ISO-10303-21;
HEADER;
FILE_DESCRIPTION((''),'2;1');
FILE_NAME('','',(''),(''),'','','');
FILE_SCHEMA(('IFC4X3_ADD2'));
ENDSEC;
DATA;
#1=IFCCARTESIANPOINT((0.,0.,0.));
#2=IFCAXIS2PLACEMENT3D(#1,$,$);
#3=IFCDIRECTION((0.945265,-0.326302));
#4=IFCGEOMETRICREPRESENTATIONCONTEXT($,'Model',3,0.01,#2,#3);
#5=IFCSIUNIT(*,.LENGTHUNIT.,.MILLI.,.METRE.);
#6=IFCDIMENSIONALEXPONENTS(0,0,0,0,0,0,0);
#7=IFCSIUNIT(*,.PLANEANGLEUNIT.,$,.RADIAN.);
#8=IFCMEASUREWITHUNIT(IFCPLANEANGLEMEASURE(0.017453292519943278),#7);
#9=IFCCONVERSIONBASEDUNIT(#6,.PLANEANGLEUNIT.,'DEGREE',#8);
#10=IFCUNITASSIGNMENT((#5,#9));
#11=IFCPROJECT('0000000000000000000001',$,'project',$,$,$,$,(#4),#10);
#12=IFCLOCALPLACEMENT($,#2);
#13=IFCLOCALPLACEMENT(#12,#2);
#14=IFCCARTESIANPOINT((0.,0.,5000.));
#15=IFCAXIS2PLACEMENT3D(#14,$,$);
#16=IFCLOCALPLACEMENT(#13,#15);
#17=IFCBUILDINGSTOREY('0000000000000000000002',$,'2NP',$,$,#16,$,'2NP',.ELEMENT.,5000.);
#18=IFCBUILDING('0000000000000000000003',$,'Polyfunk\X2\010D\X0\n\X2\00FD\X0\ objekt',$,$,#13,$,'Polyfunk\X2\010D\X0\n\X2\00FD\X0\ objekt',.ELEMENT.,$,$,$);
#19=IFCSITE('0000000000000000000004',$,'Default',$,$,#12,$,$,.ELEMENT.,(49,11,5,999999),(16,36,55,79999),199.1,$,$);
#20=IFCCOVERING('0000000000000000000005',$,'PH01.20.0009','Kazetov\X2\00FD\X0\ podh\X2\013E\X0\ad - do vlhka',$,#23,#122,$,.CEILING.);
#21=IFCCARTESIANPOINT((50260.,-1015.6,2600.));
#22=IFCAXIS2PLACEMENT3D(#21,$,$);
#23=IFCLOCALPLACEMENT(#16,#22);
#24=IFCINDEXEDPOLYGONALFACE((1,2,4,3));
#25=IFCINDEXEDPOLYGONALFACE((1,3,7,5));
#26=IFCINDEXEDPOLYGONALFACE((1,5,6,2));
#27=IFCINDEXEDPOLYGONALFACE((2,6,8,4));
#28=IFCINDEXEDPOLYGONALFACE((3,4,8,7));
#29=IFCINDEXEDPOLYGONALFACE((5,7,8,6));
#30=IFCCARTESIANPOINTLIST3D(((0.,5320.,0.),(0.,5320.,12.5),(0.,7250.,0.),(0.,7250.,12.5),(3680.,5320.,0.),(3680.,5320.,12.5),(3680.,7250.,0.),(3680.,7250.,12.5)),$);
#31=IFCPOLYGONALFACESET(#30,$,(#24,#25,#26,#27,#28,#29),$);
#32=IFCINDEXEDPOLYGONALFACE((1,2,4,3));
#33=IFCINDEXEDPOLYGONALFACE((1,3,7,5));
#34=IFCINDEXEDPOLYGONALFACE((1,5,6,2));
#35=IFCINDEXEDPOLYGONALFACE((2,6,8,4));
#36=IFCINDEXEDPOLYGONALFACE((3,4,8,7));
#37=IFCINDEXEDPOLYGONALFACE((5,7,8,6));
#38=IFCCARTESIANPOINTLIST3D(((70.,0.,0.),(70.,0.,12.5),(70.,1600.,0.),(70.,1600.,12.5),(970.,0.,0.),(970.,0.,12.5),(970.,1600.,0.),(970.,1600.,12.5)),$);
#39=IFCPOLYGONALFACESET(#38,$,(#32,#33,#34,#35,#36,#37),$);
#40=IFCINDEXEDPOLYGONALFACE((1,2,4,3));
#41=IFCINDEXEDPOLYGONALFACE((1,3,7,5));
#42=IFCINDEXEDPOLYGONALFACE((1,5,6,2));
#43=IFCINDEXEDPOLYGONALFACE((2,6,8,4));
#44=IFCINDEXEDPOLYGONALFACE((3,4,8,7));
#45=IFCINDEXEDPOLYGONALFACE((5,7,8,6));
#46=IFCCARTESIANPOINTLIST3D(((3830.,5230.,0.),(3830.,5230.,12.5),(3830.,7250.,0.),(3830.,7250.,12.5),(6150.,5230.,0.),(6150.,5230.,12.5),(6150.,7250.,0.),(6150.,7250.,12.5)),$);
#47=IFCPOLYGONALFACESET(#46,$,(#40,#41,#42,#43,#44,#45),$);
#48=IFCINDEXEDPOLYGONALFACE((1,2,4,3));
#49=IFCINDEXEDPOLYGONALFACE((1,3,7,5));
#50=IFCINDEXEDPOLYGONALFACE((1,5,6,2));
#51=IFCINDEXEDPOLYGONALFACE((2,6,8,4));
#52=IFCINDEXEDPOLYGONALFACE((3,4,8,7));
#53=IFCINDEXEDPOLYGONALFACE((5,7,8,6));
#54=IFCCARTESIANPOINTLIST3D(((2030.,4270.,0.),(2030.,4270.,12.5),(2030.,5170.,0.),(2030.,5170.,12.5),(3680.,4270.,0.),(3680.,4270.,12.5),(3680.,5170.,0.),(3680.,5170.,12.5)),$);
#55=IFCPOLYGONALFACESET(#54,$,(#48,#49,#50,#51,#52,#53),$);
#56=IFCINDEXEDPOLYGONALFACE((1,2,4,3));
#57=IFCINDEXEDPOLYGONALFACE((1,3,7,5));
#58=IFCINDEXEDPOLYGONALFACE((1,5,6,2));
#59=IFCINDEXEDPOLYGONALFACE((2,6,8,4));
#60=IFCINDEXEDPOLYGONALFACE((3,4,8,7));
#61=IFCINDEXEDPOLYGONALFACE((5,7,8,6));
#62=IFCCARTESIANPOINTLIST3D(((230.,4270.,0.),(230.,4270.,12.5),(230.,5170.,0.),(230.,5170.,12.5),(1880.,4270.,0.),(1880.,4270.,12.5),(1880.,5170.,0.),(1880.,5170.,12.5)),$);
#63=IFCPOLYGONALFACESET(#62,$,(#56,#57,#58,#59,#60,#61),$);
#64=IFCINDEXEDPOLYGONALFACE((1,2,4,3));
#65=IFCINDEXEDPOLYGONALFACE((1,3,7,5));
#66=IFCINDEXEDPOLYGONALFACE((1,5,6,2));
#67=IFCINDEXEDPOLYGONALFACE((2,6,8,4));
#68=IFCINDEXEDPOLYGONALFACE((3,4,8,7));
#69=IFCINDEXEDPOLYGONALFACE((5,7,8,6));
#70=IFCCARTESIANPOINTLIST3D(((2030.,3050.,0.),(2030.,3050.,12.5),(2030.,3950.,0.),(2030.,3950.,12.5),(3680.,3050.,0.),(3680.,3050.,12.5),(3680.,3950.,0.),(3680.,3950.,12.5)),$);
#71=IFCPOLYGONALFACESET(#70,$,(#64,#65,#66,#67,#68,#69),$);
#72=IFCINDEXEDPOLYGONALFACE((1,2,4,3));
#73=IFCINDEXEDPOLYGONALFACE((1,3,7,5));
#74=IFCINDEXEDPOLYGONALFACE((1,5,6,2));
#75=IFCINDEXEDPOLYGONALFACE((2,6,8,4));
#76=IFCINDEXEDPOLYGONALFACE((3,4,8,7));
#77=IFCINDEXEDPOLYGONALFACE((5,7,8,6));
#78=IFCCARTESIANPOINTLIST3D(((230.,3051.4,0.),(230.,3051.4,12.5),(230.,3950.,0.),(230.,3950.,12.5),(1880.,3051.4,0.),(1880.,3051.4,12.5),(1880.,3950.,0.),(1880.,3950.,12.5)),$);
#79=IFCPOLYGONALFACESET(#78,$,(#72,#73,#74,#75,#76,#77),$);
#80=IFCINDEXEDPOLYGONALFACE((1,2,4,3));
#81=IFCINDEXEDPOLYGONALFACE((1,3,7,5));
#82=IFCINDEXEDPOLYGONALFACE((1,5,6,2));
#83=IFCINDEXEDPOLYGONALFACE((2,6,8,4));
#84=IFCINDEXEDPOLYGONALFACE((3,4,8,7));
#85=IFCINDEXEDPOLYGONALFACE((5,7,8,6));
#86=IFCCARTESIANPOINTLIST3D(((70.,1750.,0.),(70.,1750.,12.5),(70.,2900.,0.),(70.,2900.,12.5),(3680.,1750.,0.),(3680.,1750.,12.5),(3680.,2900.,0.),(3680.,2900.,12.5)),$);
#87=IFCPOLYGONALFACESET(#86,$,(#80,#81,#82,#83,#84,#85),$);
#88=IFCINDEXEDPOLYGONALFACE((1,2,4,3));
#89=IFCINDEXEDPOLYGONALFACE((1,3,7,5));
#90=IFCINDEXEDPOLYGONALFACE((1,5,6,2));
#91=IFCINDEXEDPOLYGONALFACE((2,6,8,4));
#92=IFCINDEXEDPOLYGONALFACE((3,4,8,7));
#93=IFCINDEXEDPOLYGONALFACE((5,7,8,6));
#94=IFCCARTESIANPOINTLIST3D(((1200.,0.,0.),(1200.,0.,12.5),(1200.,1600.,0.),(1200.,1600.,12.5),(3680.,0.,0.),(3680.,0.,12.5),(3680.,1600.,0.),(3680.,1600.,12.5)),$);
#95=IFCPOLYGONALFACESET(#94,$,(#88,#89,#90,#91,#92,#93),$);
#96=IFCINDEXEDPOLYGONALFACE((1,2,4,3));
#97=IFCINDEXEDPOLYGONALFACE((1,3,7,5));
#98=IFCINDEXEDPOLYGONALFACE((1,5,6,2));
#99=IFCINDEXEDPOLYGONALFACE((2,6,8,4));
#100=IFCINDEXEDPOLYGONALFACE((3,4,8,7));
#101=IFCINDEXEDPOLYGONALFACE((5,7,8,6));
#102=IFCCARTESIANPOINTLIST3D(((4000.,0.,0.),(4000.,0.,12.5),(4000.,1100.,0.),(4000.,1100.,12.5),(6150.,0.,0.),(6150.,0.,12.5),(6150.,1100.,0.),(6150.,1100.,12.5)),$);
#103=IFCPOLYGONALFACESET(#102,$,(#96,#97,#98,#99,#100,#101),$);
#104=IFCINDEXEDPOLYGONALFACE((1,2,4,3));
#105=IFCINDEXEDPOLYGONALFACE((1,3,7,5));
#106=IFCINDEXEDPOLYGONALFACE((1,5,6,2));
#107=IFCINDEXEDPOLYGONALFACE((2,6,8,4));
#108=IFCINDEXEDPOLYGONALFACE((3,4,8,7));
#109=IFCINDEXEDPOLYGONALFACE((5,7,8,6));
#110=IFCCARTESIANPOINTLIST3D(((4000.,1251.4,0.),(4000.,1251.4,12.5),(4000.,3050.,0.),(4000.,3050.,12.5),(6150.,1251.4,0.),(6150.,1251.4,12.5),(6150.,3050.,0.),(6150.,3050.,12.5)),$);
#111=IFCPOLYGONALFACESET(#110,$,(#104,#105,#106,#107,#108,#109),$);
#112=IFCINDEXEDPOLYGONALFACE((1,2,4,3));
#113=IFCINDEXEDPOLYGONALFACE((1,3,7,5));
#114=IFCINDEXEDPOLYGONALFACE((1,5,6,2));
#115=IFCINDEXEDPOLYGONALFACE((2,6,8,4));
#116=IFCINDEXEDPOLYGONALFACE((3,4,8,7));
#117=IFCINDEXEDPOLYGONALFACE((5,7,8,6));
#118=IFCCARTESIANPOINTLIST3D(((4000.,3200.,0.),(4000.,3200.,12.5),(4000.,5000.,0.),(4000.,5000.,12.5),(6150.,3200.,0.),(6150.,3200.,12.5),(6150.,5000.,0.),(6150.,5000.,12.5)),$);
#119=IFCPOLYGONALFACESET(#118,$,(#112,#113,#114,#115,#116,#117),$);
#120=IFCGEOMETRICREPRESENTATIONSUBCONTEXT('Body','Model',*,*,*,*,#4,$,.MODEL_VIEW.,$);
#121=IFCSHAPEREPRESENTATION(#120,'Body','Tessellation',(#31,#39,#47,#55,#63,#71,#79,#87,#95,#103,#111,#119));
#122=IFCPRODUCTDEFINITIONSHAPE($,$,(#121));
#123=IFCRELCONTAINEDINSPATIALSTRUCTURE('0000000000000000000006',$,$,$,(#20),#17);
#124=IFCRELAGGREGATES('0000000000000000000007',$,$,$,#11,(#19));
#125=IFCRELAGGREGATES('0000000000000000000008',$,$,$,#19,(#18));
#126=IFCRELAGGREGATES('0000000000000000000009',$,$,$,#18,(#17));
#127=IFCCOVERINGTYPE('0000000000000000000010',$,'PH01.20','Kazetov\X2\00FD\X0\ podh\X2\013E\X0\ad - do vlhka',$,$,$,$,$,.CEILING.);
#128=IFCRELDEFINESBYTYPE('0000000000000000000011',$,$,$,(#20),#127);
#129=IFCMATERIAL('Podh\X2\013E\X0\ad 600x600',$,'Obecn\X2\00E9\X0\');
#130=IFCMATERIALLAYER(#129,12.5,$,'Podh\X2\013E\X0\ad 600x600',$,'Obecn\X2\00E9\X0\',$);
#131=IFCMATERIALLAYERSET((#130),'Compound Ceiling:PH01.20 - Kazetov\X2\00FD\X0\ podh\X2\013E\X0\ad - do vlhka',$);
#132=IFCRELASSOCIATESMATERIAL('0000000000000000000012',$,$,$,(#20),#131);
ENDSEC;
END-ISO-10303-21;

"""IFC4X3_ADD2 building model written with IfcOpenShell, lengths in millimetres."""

from ifc_helpers import new_model, entity, si_unit, converted_unit, direction, frame, frame_2d, origin, origin_2d_with_axis, place, context, subcontext, project, spatial, rectangle, extrude, material, layer, layer_set, layer_usage, type_object, element, save


model = new_model("IFC4X3_ADD2")

# Units and contexts
model_context = context("Model", 3, precision=0.01, world=origin(), true_north=direction((0.945265, -0.326302)))
body_context = subcontext(model_context, "Body", "Model", "MODEL_VIEW")
ifc_project = project(units=[si_unit("LENGTHUNIT", "METRE", prefix="MILLI"), converted_unit("PLANEANGLEUNIT", "DEGREE", entity("IfcPlaneAngleMeasure", 0.017453292519943278), si_unit("PLANEANGLEUNIT", "RADIAN"), dimensions=[0, 0, 0, 0, 0, 0, 0])], contexts=[model_context])

# Site, building, storey
site_placement = place(None, origin())
site = spatial("IfcSite", under=ifc_project, at=site_placement, Name="Default", CompositionType="ELEMENT", RefLatitude=(49, 11, 5, 999999), RefLongitude=(16, 36, 55, 79999), RefElevation=199.1)
building_placement = place(site_placement, origin())
building = spatial("IfcBuilding", under=site, at=building_placement, Name="Polyfunkčný objekt", LongName="Polyfunkčný objekt", CompositionType="ELEMENT")
storey_placement = place(building_placement, frame((0.0, 0.0, 5000.0)))
storey = spatial("IfcBuildingStorey", under=building, at=storey_placement, Name="2NP", LongName="2NP", CompositionType="ELEMENT", Elevation=5000.0)

# Covering
ifc_material_1 = material(Name="Podhľad 600x600", Category="Obecné")
ifc_layer_1 = layer(ifc_material_1, 12.5, Name="Podhľad 600x600", Category="Obecné")
ifc_layer_set_1 = layer_set([ifc_layer_1], Name="Compound Ceiling:PH01.20 - Kazetový podhľad - do vlhka")
ifc_layer_usage_1 = layer_usage(ifc_layer_set_1, "AXIS3", "NEGATIVE", 0.0)
covering_type = type_object("IfcCoveringType", Name="PH01.20", Description="Kazetový podhľad - do vlhka", PredefinedType="CEILING")
covering_placement = place(storey_placement, frame((50260.0, -1015.6, 2600.0)))
element("IfcCovering", 1, at=covering_placement, inside=storey, type_object=covering_type, material=ifc_layer_usage_1, Name="PH01.20.0009", Description="Kazetový podhľad - do vlhka", PredefinedType="CEILING", context=body_context, shape_type="SweptSolid", body=[
    extrude(rectangle(XDim=1930.0, YDim=3680.0, at=frame_2d((0.0, 0.0), x_axis=(1.0, 0.0))), frame((1840.0, 6285.0, 0.0), z_axis=(0.0, 0.0, 1.0), x_axis=(0.0, -1.0, 0.0)), (0.0, 0.0, 1.0), 12.5),
    extrude(rectangle(XDim=1600.0, YDim=900.0, at=origin_2d_with_axis()), frame((520.0, 800.0, 0.0), z_axis=(0.0, 0.0, 1.0), x_axis=(0.0, 1.0, 0.0)), (0.0, 0.0, 1.0), 12.5),
    extrude(rectangle(XDim=2320.0, YDim=2020.0, at=frame_2d((0.0, 0.0), x_axis=(1.0, 0.0))), frame((4990.0, 6240.0, 0.0), z_axis=(0.0, 0.0, 1.0), x_axis=(-1.0, 0.0, 0.0)), (0.0, 0.0, 1.0), 12.5),
    extrude(rectangle(XDim=900.0, YDim=1650.0, at=frame_2d((0.0, 0.0), x_axis=(1.0, 0.0))), frame((2855.0, 4720.0, 0.0), z_axis=(0.0, 0.0, 1.0), x_axis=(0.0, 1.0, 0.0)), (0.0, 0.0, 1.0), 12.5),
    extrude(rectangle(XDim=1650.0, YDim=900.0, at=frame_2d((0.0, 0.0), x_axis=(1.0, 0.0))), frame((1055.0, 4720.0, 0.0), z_axis=(0.0, 0.0, 1.0), x_axis=(-1.0, 0.0, 0.0)), (0.0, 0.0, 1.0), 12.5),
    extrude(rectangle(XDim=900.0, YDim=1650.0, at=frame_2d((0.0, 0.0), x_axis=(1.0, 0.0))), frame((2855.0, 3500.0, 0.0), z_axis=(0.0, 0.0, 1.0), x_axis=(0.0, -1.0, 0.0)), (0.0, 0.0, 1.0), 12.5),
    extrude(rectangle(XDim=1650.0, YDim=898.6, at=frame_2d((0.0, 0.0), x_axis=(1.0, 0.0))), frame((1055.0, 3500.7, 0.0), z_axis=(0.0, 0.0, 1.0), x_axis=(-1.0, 0.0, 0.0)), (0.0, 0.0, 1.0), 12.5),
    extrude(rectangle(XDim=3610.0, YDim=1150.0, at=frame_2d((0.0, 0.0), x_axis=(1.0, 0.0))), frame((1875.0, 2325.0, 0.0), z_axis=(0.0, 0.0, 1.0), x_axis=(-1.0, 0.0, 0.0)), (0.0, 0.0, 1.0), 12.5),
    extrude(rectangle(XDim=2480.0, YDim=1600.0, at=origin_2d_with_axis()), frame((2440.0, 800.0, 0.0), z_axis=(0.0, 0.0, 1.0), x_axis=(-1.0, 0.0, 0.0)), (0.0, 0.0, 1.0), 12.5),
    extrude(rectangle(XDim=1100.0, YDim=2150.0, at=frame_2d((0.0, 0.0), x_axis=(1.0, 0.0))), frame((5075.0, 550.0, 0.0), z_axis=(0.0, 0.0, 1.0), x_axis=(0.0, 1.0, 0.0)), (0.0, 0.0, 1.0), 12.5),
    extrude(rectangle(XDim=1798.6, YDim=2150.0, at=origin_2d_with_axis()), frame((5075.0, 2150.7, 0.0), z_axis=(0.0, 0.0, 1.0), x_axis=(0.0, 1.0, 0.0)), (0.0, 0.0, 1.0), 12.5),
    extrude(rectangle(XDim=1800.0, YDim=2150.0, at=frame_2d((0.0, 0.0), x_axis=(1.0, 0.0))), frame((5075.0, 4100.0, 0.0), z_axis=(0.0, 0.0, 1.0), x_axis=(0.0, 1.0, 0.0)), (0.0, 0.0, 1.0), 12.5),
])

save(model, "model.ifc")
